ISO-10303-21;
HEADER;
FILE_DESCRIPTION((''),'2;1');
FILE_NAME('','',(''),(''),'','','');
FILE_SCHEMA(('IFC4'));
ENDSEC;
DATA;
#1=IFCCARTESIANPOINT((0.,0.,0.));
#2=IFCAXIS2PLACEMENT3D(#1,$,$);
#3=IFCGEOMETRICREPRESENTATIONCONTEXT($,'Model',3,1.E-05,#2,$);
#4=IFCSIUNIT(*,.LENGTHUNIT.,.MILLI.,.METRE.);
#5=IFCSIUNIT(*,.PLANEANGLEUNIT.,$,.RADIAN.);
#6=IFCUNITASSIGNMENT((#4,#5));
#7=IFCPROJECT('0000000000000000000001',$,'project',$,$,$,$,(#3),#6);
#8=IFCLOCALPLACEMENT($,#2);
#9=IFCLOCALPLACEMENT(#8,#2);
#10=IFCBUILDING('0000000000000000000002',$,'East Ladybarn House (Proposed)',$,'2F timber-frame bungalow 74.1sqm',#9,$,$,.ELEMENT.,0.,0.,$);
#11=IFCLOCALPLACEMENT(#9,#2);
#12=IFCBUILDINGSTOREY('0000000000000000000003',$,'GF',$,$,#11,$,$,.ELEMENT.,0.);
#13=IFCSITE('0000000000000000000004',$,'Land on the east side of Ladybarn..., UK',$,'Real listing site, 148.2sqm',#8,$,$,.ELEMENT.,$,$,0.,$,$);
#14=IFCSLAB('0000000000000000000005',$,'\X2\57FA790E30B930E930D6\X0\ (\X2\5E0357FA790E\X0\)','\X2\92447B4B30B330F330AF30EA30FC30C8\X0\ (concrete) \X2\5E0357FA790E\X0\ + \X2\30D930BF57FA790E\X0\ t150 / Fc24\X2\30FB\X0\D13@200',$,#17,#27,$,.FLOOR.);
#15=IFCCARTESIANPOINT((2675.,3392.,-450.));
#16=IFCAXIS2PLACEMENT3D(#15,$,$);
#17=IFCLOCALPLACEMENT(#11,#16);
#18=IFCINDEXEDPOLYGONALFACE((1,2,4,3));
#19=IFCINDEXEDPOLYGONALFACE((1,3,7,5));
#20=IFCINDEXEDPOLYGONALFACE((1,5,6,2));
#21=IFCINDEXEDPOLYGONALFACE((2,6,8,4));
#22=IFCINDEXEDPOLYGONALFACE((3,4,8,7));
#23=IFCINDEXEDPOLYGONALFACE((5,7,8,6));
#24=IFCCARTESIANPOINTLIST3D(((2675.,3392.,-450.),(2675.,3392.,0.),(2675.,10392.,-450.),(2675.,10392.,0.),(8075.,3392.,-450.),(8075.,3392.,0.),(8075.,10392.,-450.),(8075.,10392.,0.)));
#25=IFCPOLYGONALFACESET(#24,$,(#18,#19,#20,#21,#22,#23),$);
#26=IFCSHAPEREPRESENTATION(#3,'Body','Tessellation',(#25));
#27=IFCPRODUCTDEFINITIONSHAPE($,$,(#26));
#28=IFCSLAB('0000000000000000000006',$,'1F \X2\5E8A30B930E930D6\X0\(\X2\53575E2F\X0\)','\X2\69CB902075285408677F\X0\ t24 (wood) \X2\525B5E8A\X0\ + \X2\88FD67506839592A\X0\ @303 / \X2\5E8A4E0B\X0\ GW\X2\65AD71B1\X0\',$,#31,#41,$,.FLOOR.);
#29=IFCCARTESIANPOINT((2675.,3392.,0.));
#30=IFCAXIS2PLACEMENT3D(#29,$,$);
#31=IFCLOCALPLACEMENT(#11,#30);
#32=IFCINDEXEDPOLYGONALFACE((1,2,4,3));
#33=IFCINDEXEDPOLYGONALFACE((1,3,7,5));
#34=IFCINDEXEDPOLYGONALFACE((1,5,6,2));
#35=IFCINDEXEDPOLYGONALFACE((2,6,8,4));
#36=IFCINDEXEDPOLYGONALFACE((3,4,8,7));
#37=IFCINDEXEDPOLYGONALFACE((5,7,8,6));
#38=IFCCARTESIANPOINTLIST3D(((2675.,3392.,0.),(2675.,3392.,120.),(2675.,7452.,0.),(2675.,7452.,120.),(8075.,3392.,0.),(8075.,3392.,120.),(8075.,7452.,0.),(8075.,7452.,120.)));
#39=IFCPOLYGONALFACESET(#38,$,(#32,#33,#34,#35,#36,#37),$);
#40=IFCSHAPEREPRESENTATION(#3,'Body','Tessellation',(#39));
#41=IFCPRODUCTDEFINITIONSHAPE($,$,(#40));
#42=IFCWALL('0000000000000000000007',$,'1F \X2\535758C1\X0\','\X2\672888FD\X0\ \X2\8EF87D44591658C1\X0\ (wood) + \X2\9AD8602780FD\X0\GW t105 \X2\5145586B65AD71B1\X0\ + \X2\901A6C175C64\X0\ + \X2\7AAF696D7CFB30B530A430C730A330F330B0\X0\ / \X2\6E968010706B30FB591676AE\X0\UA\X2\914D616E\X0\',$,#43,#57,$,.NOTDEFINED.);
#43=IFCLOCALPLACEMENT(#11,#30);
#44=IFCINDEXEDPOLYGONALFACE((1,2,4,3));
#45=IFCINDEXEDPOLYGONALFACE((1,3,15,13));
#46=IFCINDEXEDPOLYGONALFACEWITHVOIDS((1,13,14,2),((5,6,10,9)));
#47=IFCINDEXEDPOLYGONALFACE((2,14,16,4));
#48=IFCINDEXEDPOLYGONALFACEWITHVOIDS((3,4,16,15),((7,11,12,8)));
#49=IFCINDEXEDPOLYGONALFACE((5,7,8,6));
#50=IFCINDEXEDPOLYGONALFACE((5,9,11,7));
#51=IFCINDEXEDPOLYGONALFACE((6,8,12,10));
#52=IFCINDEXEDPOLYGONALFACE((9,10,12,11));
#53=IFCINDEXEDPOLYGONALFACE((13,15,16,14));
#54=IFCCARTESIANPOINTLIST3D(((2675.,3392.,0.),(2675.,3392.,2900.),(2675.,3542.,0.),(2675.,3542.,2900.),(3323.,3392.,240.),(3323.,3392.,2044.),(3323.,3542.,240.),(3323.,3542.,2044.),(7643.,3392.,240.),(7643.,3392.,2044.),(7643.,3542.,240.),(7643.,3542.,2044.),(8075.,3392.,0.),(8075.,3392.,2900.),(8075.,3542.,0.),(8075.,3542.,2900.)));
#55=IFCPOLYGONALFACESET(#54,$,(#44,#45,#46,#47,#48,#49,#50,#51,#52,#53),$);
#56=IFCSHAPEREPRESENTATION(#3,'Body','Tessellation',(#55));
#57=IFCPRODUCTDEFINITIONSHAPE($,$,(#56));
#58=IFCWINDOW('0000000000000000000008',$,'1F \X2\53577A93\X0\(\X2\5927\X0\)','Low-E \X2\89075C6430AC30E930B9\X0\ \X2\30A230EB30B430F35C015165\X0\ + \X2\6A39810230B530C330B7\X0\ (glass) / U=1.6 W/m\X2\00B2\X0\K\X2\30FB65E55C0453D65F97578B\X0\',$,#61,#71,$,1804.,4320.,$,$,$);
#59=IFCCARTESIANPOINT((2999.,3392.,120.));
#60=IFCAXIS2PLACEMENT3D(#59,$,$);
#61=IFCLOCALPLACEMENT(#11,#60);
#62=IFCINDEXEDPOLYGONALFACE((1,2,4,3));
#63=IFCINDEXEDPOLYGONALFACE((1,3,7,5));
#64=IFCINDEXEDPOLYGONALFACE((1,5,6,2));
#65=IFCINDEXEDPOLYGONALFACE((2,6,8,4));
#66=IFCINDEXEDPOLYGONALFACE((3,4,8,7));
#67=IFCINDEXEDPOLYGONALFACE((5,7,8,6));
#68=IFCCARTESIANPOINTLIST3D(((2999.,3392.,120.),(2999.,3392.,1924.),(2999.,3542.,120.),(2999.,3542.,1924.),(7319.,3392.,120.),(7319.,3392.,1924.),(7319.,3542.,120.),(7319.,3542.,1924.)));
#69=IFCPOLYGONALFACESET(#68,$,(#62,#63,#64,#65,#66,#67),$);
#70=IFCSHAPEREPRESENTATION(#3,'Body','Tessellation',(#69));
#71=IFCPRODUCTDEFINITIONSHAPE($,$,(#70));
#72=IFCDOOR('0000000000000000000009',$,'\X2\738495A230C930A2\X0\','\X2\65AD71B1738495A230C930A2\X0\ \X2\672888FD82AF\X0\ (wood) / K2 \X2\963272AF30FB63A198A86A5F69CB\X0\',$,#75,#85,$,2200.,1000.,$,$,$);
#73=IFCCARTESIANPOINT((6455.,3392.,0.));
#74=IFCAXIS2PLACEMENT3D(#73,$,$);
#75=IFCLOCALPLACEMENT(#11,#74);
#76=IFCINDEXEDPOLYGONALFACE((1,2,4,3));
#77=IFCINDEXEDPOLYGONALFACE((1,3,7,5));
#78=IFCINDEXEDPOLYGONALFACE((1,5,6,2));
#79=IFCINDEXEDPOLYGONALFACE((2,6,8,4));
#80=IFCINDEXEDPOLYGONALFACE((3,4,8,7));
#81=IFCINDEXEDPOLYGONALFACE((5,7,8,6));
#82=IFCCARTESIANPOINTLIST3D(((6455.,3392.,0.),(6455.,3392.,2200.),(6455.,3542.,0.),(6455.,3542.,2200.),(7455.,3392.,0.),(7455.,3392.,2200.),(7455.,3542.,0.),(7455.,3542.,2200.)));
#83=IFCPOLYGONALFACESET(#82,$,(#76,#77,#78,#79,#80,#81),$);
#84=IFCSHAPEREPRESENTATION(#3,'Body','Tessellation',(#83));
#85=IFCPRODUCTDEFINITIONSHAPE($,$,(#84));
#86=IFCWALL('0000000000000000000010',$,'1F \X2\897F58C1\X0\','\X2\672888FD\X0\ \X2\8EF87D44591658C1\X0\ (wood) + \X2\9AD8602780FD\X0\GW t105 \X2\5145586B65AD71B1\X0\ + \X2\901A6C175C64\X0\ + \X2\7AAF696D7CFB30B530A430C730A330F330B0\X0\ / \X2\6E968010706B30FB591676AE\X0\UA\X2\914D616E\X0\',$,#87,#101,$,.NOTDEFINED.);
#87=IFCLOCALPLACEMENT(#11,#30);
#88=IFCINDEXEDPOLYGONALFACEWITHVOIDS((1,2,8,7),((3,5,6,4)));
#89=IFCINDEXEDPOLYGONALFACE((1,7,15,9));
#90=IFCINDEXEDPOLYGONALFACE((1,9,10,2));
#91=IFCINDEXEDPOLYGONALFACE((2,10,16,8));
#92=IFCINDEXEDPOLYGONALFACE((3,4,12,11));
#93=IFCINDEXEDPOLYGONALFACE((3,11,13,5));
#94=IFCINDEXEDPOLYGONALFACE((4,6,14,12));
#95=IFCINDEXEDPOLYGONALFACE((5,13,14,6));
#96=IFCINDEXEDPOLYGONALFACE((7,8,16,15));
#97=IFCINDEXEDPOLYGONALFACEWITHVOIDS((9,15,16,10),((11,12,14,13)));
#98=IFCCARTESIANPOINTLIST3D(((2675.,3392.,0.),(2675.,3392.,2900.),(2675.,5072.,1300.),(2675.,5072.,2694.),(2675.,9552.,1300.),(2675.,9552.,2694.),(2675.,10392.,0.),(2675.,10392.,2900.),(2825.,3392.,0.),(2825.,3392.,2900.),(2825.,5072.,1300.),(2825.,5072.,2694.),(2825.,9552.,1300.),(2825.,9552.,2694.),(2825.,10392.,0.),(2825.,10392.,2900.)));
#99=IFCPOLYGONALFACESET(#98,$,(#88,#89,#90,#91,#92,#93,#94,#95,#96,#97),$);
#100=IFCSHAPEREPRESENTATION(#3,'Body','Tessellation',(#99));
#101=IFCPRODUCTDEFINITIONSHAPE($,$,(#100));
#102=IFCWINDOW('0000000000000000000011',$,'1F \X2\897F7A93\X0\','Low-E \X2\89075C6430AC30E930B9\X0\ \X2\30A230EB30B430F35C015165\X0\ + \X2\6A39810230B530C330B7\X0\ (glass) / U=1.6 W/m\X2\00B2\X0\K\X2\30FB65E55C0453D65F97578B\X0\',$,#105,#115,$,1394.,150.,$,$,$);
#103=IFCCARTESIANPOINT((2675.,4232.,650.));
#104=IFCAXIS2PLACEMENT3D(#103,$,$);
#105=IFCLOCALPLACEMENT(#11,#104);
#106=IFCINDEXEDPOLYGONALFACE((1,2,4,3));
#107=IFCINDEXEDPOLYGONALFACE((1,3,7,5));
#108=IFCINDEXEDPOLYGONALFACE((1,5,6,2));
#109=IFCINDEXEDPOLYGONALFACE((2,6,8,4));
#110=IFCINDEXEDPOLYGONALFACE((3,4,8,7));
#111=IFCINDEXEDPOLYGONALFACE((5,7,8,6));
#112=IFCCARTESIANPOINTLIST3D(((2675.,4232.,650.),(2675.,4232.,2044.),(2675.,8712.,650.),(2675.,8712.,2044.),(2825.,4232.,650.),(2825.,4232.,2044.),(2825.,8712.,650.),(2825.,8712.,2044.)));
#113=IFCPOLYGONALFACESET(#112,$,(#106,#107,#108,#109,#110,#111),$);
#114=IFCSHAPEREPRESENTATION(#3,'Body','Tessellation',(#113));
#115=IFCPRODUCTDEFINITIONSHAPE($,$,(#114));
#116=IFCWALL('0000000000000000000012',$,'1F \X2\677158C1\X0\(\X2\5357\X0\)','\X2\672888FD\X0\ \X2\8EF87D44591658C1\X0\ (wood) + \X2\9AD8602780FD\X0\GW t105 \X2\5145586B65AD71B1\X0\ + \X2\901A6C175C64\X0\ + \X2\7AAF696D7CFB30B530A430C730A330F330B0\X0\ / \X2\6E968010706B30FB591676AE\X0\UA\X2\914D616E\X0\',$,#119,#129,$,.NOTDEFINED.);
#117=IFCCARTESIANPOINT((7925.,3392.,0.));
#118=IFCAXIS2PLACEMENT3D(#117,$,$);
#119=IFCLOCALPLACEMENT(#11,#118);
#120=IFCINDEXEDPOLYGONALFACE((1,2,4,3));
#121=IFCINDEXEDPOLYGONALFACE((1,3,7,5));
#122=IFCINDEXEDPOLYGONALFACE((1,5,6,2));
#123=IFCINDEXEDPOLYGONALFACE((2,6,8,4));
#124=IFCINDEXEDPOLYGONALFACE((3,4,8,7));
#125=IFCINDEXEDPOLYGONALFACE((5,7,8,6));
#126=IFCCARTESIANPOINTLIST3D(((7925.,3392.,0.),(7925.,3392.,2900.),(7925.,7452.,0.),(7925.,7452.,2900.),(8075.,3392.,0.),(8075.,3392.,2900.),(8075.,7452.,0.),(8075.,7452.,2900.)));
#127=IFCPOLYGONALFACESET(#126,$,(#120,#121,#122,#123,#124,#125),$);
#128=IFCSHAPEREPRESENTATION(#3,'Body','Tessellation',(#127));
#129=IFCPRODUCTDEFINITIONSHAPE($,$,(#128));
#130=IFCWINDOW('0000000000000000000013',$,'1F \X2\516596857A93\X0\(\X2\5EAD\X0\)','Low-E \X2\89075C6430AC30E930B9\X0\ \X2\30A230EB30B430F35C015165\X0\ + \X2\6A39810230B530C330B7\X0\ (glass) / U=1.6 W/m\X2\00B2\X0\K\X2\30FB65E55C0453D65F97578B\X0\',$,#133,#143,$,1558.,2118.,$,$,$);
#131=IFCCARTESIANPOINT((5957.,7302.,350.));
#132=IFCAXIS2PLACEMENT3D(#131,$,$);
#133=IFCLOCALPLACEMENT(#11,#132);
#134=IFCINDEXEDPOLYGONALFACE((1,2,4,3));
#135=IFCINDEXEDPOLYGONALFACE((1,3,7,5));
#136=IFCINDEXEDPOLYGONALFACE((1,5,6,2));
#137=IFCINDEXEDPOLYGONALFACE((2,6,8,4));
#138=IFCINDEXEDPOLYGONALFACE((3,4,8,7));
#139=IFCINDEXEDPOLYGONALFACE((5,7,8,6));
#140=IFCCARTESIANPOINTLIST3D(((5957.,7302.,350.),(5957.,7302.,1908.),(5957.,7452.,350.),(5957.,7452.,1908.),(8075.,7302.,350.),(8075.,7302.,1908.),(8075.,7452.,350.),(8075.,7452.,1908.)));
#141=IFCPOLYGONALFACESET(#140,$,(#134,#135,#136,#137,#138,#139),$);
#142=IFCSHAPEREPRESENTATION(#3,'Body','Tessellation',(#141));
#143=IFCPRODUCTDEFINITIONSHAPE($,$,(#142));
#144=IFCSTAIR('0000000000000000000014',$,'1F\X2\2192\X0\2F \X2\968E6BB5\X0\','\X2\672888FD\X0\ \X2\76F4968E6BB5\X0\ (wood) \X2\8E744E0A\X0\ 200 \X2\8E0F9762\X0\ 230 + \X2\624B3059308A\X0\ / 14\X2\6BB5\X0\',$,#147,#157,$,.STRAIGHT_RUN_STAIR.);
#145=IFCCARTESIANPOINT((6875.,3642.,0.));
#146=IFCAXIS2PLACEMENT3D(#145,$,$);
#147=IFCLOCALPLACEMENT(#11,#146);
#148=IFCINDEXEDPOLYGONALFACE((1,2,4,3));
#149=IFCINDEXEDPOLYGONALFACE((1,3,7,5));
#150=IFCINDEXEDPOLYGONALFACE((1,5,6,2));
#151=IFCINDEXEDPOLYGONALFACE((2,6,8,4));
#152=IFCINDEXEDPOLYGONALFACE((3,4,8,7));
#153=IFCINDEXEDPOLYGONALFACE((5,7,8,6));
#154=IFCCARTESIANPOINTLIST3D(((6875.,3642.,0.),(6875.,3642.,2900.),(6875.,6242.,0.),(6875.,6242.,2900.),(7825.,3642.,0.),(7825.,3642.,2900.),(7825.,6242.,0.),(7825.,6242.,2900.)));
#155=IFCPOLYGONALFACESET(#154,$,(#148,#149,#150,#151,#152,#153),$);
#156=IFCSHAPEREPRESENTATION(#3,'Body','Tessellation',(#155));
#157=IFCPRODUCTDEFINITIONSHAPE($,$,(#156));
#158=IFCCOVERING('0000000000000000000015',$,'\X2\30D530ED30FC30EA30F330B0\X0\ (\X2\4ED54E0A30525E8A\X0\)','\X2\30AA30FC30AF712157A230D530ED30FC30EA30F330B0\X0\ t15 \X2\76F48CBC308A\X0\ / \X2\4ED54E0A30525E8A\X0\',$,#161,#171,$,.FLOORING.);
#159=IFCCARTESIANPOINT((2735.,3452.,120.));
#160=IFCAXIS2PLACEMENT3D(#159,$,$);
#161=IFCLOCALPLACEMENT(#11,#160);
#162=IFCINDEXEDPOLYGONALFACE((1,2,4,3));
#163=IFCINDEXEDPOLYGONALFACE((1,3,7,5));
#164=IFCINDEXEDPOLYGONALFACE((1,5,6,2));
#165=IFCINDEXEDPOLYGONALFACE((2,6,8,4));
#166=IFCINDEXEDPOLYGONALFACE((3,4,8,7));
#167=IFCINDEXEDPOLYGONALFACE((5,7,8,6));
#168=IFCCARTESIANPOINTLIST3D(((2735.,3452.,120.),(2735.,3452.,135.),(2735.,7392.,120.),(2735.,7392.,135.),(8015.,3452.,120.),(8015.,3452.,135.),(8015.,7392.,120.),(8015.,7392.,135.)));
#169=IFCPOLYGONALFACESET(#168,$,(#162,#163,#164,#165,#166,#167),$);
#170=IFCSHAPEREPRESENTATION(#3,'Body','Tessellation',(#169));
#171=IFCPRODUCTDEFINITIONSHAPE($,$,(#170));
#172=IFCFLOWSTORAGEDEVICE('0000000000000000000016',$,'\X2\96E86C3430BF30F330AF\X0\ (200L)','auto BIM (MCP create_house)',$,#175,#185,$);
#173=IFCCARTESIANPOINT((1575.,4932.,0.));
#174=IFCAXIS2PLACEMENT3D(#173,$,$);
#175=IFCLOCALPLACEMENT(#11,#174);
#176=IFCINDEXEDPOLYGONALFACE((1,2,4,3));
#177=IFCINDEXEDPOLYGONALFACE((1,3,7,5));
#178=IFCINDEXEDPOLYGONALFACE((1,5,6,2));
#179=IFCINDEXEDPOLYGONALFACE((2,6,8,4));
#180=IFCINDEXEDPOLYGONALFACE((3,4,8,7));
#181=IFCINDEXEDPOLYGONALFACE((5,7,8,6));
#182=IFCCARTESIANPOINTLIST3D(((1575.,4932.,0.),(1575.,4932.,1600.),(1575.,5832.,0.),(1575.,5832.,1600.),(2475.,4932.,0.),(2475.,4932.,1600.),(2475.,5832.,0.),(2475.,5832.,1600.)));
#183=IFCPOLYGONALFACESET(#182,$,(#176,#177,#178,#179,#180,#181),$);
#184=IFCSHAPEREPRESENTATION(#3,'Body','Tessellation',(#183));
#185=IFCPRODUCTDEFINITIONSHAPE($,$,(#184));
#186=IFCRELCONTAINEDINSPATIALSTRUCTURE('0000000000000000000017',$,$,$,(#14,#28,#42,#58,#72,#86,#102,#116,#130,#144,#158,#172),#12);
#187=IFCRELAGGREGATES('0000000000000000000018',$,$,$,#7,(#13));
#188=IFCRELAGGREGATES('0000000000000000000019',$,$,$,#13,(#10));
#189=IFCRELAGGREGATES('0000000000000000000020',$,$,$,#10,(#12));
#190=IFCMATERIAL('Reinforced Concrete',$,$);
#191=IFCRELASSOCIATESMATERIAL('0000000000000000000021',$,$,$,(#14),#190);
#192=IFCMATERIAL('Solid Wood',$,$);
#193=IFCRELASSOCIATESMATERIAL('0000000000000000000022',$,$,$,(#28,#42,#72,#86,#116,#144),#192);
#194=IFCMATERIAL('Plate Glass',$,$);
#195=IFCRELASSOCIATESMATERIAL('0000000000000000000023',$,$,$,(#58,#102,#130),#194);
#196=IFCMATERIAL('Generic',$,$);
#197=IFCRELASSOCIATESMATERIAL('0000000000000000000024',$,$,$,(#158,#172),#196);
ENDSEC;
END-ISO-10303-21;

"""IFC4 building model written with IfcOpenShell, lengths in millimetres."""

from ifc_helpers import new_model, si_unit, frame, frame_2d, origin, place, context, project, spatial, rectangle, extrude, material, element, fill, save


model = new_model("IFC4")

# Units and contexts
model_context = context("Model", 3, precision=1e-05, world=origin())
ifc_project = project(units=[si_unit("LENGTHUNIT", "METRE", prefix="MILLI"), si_unit("PLANEANGLEUNIT", "RADIAN")], contexts=[model_context])

# Site, building, storey
site_placement = place(None, origin())
site = spatial("IfcSite", under=ifc_project, at=site_placement, Name="Land on the east side of Ladybarn..., UK", ObjectType="Real listing site, 148.2sqm", CompositionType="ELEMENT", RefElevation=0.0)
building_placement = place(site_placement, origin())
building = spatial("IfcBuilding", under=site, at=building_placement, Name="East Ladybarn House (Proposed)", ObjectType="2F timber-frame bungalow 74.1sqm", CompositionType="ELEMENT", ElevationOfRefHeight=0.0, ElevationOfTerrain=0.0)
storey_placement = place(building_placement, origin())
storey = spatial("IfcBuildingStorey", under=building, at=storey_placement, Name="GF", CompositionType="ELEMENT", Elevation=0.0)

# Slabs
ifc_material_1 = material(Name="Reinforced Concrete")
slab_1_placement = place(storey_placement, frame((2675.0, 3392.0, -450.0)))
element("IfcSlab", 1, at=slab_1_placement, inside=storey, material=ifc_material_1, Name="基礎スラブ (布基礎)", Description="鉄筋コンクリート (concrete) 布基礎 + ベタ基礎 t150 / Fc24・D13@200", PredefinedType="FLOOR", context=model_context, shape_type="SweptSolid", body=[
    extrude(rectangle(XDim=5400.0, YDim=7000.0, at=frame_2d((2700.0, 3500.0))), frame((2675.0, 3392.0, -450.0)), (0.0, 0.0, 1.0), 450.0),
])
ifc_material_2 = material(Name="Solid Wood")
slab_2_placement = place(storey_placement, frame((2675.0, 3392.0, 0.0)))
element("IfcSlab", 2, at=slab_2_placement, inside=storey, material=ifc_material_2, Name="1F 床スラブ(南帯)", Description="構造用合板 t24 (wood) 剛床 + 製材根太 @303 / 床下 GW断熱", PredefinedType="FLOOR", context=model_context, shape_type="SweptSolid", body=[
    extrude(rectangle(XDim=5400.0, YDim=4060.0, at=frame_2d((2700.0, 2030.0))), frame((2675.0, 3392.0, 0.0)), (0.0, 0.0, 1.0), 120.0),
])

# Wall, openings, window, door
wall_1_placement = place(storey_placement, frame((2675.0, 3392.0, 0.0)))
wall_1 = element("IfcWall", 3, at=wall_1_placement, inside=storey, material=ifc_material_2, Name="1F 南壁", Description="木製 軸組外壁 (wood) + 高性能GW t105 充填断熱 + 通気層 + 窯業系サイディング / 準耐火・外皮UA配慮", PredefinedType="NOTDEFINED", context=model_context, shape_type="SweptSolid", body=[
    extrude(rectangle(XDim=5400.0, YDim=150.0, at=frame_2d((2700.0, 75.0))), frame((2675.0, 3392.0, 0.0)), (0.0, 0.0, 1.0), 2900.0),
])
opening_1_placement = place(storey_placement, frame((2999.0, 3392.0, 120.0)))
opening_1 = element("IfcOpeningElement", 4, at=opening_1_placement, cuts=wall_1, PredefinedType="NOTDEFINED", context=model_context, shape_type="SweptSolid", body=[
    extrude(rectangle(XDim=4320.0, YDim=150.0, at=frame_2d((2160.0, 75.0))), frame((2999.0, 3392.0, 120.0)), (0.0, 0.0, 1.0), 1804.0),
])
opening_2_placement = place(storey_placement, frame((6455.0, 3392.0, 0.0)))
opening_2 = element("IfcOpeningElement", 5, at=opening_2_placement, cuts=wall_1, PredefinedType="NOTDEFINED", context=model_context, shape_type="SweptSolid", body=[
    extrude(rectangle(XDim=1000.0, YDim=150.0, at=frame_2d((500.0, 75.0))), frame((6455.0, 3392.0, 0.0)), (0.0, 0.0, 1.0), 2200.0),
])
ifc_material_3 = material(Name="Plate Glass")
window_1_placement = place(storey_placement, frame((2999.0, 3392.0, 120.0)))
window_1 = element("IfcWindow", 6, at=window_1_placement, inside=storey, material=ifc_material_3, Name="1F 南窓(大)", Description="Low-E 複層ガラス アルゴン封入 + 樹脂サッシ (glass) / U=1.6 W/m²K・日射取得型", OverallHeight=1804.0, OverallWidth=4320.0, context=model_context, shape_type="SweptSolid", body=[
    extrude(rectangle(XDim=4320.0, YDim=150.0, at=frame_2d((2160.0, 75.0))), frame((2999.0, 3392.0, 120.0)), (0.0, 0.0, 1.0), 1804.0),
])
fill(opening_1, window_1)
door_1_placement = place(storey_placement, frame((6455.0, 3392.0, 0.0)))
door_1 = element("IfcDoor", 7, at=door_1_placement, inside=storey, material=ifc_material_2, Name="玄関ドア", Description="断熱玄関ドア 木製芯 (wood) / K2 防犯・採風機構", OverallHeight=2200.0, OverallWidth=1000.0, context=model_context, shape_type="SweptSolid", body=[
    extrude(rectangle(XDim=1000.0, YDim=150.0, at=frame_2d((500.0, 75.0))), frame((6455.0, 3392.0, 0.0)), (0.0, 0.0, 1.0), 2200.0),
])
fill(opening_2, door_1)

# Walls, openings, windows
wall_2_placement = place(storey_placement, frame((2675.0, 3392.0, 0.0)))
wall_2 = element("IfcWall", 8, at=wall_2_placement, inside=storey, material=ifc_material_2, Name="1F 西壁", Description="木製 軸組外壁 (wood) + 高性能GW t105 充填断熱 + 通気層 + 窯業系サイディング / 準耐火・外皮UA配慮", PredefinedType="NOTDEFINED", context=model_context, shape_type="SweptSolid", body=[
    extrude(rectangle(XDim=150.0, YDim=7000.0, at=frame_2d((75.0, 3500.0))), frame((2675.0, 3392.0, 0.0)), (0.0, 0.0, 1.0), 2900.0),
])
opening_3_placement = place(storey_placement, frame((2675.0, 4232.0, 650.0)))
opening_3 = element("IfcOpeningElement", 9, at=opening_3_placement, cuts=wall_2, PredefinedType="NOTDEFINED", context=model_context, shape_type="SweptSolid", body=[
    extrude(rectangle(XDim=150.0, YDim=4480.0, at=frame_2d((75.0, 2240.0))), frame((2675.0, 4232.0, 650.0)), (0.0, 0.0, 1.0), 1394.0),
])
window_2_placement = place(storey_placement, frame((2675.0, 4232.0, 650.0)))
window_2 = element("IfcWindow", 10, at=window_2_placement, inside=storey, material=ifc_material_3, Name="1F 西窓", Description="Low-E 複層ガラス アルゴン封入 + 樹脂サッシ (glass) / U=1.6 W/m²K・日射取得型", OverallHeight=1394.0, OverallWidth=150.0, context=model_context, shape_type="SweptSolid", body=[
    extrude(rectangle(XDim=150.0, YDim=4480.0, at=frame_2d((75.0, 2240.0))), frame((2675.0, 4232.0, 650.0)), (0.0, 0.0, 1.0), 1394.0),
])
fill(opening_3, window_2)
wall_3_placement = place(storey_placement, frame((7925.0, 3392.0, 0.0)))
wall_3 = element("IfcWall", 11, at=wall_3_placement, inside=storey, material=ifc_material_2, Name="1F 東壁(南)", Description="木製 軸組外壁 (wood) + 高性能GW t105 充填断熱 + 通気層 + 窯業系サイディング / 準耐火・外皮UA配慮", PredefinedType="NOTDEFINED", context=model_context, shape_type="SweptSolid", body=[
    extrude(rectangle(XDim=150.0, YDim=4060.0, at=frame_2d((75.0, 2030.0))), frame((7925.0, 3392.0, 0.0)), (0.0, 0.0, 1.0), 2900.0),
])
opening_4_placement = place(storey_placement, frame((5957.0, 7302.0, 350.0)))
opening_4 = element("IfcOpeningElement", 12, at=opening_4_placement, cuts=wall_3, PredefinedType="NOTDEFINED", context=model_context, shape_type="SweptSolid", body=[
    extrude(rectangle(XDim=2118.0, YDim=150.0, at=frame_2d((1059.0, 75.0))), frame((5957.0, 7302.0, 350.0)), (0.0, 0.0, 1.0), 1558.0),
])
window_3_placement = place(storey_placement, frame((5957.0, 7302.0, 350.0)))
window_3 = element("IfcWindow", 13, at=window_3_placement, inside=storey, material=ifc_material_3, Name="1F 入隅窓(庭)", Description="Low-E 複層ガラス アルゴン封入 + 樹脂サッシ (glass) / U=1.6 W/m²K・日射取得型", OverallHeight=1558.0, OverallWidth=2118.0, context=model_context, shape_type="SweptSolid", body=[
    extrude(rectangle(XDim=2118.0, YDim=150.0, at=frame_2d((1059.0, 75.0))), frame((5957.0, 7302.0, 350.0)), (0.0, 0.0, 1.0), 1558.0),
])
fill(opening_4, window_3)

# Stair
stair_placement = place(storey_placement, frame((6875.0, 3642.0, 0.0)))
element("IfcStair", 14, at=stair_placement, inside=storey, material=ifc_material_2, Name="1F→2F 階段", Description="木製 直階段 (wood) 蹴上 200 踏面 230 + 手すり / 14段", PredefinedType="STRAIGHT_RUN_STAIR", context=model_context, shape_type="SweptSolid", body=[
    extrude(rectangle(XDim=950.0, YDim=2600.0, at=frame_2d((475.0, 1300.0))), frame((6875.0, 3642.0, 0.0)), (0.0, 0.0, 1.0), 2900.0),
])

# Covering
ifc_material_4 = material(Name="Generic")
covering_placement = place(storey_placement, frame((2735.0, 3452.0, 120.0)))
element("IfcCovering", 15, at=covering_placement, inside=storey, material=ifc_material_4, Name="フローリング (仕上げ床)", Description="オーク無垢フローリング t15 直貼り / 仕上げ床", PredefinedType="FLOORING", context=model_context, shape_type="SweptSolid", body=[
    extrude(rectangle(XDim=5280.0, YDim=3940.0, at=frame_2d((2640.0, 1970.0))), frame((2735.0, 3452.0, 120.0)), (0.0, 0.0, 1.0), 15.0),
])

# Flow storage device
flow_storage_device_placement = place(storey_placement, frame((1575.0, 4932.0, 0.0)))
element("IfcFlowStorageDevice", 16, at=flow_storage_device_placement, inside=storey, material=ifc_material_4, Name="雨水タンク (200L)", Description="auto BIM (MCP create_house)", context=model_context, shape_type="SweptSolid", body=[
    extrude(rectangle(XDim=900.0, YDim=900.0, at=frame_2d((450.0, 450.0))), frame((1575.0, 4932.0, 0.0)), (0.0, 0.0, 1.0), 1600.0),
])

save(model, "model.ifc")
